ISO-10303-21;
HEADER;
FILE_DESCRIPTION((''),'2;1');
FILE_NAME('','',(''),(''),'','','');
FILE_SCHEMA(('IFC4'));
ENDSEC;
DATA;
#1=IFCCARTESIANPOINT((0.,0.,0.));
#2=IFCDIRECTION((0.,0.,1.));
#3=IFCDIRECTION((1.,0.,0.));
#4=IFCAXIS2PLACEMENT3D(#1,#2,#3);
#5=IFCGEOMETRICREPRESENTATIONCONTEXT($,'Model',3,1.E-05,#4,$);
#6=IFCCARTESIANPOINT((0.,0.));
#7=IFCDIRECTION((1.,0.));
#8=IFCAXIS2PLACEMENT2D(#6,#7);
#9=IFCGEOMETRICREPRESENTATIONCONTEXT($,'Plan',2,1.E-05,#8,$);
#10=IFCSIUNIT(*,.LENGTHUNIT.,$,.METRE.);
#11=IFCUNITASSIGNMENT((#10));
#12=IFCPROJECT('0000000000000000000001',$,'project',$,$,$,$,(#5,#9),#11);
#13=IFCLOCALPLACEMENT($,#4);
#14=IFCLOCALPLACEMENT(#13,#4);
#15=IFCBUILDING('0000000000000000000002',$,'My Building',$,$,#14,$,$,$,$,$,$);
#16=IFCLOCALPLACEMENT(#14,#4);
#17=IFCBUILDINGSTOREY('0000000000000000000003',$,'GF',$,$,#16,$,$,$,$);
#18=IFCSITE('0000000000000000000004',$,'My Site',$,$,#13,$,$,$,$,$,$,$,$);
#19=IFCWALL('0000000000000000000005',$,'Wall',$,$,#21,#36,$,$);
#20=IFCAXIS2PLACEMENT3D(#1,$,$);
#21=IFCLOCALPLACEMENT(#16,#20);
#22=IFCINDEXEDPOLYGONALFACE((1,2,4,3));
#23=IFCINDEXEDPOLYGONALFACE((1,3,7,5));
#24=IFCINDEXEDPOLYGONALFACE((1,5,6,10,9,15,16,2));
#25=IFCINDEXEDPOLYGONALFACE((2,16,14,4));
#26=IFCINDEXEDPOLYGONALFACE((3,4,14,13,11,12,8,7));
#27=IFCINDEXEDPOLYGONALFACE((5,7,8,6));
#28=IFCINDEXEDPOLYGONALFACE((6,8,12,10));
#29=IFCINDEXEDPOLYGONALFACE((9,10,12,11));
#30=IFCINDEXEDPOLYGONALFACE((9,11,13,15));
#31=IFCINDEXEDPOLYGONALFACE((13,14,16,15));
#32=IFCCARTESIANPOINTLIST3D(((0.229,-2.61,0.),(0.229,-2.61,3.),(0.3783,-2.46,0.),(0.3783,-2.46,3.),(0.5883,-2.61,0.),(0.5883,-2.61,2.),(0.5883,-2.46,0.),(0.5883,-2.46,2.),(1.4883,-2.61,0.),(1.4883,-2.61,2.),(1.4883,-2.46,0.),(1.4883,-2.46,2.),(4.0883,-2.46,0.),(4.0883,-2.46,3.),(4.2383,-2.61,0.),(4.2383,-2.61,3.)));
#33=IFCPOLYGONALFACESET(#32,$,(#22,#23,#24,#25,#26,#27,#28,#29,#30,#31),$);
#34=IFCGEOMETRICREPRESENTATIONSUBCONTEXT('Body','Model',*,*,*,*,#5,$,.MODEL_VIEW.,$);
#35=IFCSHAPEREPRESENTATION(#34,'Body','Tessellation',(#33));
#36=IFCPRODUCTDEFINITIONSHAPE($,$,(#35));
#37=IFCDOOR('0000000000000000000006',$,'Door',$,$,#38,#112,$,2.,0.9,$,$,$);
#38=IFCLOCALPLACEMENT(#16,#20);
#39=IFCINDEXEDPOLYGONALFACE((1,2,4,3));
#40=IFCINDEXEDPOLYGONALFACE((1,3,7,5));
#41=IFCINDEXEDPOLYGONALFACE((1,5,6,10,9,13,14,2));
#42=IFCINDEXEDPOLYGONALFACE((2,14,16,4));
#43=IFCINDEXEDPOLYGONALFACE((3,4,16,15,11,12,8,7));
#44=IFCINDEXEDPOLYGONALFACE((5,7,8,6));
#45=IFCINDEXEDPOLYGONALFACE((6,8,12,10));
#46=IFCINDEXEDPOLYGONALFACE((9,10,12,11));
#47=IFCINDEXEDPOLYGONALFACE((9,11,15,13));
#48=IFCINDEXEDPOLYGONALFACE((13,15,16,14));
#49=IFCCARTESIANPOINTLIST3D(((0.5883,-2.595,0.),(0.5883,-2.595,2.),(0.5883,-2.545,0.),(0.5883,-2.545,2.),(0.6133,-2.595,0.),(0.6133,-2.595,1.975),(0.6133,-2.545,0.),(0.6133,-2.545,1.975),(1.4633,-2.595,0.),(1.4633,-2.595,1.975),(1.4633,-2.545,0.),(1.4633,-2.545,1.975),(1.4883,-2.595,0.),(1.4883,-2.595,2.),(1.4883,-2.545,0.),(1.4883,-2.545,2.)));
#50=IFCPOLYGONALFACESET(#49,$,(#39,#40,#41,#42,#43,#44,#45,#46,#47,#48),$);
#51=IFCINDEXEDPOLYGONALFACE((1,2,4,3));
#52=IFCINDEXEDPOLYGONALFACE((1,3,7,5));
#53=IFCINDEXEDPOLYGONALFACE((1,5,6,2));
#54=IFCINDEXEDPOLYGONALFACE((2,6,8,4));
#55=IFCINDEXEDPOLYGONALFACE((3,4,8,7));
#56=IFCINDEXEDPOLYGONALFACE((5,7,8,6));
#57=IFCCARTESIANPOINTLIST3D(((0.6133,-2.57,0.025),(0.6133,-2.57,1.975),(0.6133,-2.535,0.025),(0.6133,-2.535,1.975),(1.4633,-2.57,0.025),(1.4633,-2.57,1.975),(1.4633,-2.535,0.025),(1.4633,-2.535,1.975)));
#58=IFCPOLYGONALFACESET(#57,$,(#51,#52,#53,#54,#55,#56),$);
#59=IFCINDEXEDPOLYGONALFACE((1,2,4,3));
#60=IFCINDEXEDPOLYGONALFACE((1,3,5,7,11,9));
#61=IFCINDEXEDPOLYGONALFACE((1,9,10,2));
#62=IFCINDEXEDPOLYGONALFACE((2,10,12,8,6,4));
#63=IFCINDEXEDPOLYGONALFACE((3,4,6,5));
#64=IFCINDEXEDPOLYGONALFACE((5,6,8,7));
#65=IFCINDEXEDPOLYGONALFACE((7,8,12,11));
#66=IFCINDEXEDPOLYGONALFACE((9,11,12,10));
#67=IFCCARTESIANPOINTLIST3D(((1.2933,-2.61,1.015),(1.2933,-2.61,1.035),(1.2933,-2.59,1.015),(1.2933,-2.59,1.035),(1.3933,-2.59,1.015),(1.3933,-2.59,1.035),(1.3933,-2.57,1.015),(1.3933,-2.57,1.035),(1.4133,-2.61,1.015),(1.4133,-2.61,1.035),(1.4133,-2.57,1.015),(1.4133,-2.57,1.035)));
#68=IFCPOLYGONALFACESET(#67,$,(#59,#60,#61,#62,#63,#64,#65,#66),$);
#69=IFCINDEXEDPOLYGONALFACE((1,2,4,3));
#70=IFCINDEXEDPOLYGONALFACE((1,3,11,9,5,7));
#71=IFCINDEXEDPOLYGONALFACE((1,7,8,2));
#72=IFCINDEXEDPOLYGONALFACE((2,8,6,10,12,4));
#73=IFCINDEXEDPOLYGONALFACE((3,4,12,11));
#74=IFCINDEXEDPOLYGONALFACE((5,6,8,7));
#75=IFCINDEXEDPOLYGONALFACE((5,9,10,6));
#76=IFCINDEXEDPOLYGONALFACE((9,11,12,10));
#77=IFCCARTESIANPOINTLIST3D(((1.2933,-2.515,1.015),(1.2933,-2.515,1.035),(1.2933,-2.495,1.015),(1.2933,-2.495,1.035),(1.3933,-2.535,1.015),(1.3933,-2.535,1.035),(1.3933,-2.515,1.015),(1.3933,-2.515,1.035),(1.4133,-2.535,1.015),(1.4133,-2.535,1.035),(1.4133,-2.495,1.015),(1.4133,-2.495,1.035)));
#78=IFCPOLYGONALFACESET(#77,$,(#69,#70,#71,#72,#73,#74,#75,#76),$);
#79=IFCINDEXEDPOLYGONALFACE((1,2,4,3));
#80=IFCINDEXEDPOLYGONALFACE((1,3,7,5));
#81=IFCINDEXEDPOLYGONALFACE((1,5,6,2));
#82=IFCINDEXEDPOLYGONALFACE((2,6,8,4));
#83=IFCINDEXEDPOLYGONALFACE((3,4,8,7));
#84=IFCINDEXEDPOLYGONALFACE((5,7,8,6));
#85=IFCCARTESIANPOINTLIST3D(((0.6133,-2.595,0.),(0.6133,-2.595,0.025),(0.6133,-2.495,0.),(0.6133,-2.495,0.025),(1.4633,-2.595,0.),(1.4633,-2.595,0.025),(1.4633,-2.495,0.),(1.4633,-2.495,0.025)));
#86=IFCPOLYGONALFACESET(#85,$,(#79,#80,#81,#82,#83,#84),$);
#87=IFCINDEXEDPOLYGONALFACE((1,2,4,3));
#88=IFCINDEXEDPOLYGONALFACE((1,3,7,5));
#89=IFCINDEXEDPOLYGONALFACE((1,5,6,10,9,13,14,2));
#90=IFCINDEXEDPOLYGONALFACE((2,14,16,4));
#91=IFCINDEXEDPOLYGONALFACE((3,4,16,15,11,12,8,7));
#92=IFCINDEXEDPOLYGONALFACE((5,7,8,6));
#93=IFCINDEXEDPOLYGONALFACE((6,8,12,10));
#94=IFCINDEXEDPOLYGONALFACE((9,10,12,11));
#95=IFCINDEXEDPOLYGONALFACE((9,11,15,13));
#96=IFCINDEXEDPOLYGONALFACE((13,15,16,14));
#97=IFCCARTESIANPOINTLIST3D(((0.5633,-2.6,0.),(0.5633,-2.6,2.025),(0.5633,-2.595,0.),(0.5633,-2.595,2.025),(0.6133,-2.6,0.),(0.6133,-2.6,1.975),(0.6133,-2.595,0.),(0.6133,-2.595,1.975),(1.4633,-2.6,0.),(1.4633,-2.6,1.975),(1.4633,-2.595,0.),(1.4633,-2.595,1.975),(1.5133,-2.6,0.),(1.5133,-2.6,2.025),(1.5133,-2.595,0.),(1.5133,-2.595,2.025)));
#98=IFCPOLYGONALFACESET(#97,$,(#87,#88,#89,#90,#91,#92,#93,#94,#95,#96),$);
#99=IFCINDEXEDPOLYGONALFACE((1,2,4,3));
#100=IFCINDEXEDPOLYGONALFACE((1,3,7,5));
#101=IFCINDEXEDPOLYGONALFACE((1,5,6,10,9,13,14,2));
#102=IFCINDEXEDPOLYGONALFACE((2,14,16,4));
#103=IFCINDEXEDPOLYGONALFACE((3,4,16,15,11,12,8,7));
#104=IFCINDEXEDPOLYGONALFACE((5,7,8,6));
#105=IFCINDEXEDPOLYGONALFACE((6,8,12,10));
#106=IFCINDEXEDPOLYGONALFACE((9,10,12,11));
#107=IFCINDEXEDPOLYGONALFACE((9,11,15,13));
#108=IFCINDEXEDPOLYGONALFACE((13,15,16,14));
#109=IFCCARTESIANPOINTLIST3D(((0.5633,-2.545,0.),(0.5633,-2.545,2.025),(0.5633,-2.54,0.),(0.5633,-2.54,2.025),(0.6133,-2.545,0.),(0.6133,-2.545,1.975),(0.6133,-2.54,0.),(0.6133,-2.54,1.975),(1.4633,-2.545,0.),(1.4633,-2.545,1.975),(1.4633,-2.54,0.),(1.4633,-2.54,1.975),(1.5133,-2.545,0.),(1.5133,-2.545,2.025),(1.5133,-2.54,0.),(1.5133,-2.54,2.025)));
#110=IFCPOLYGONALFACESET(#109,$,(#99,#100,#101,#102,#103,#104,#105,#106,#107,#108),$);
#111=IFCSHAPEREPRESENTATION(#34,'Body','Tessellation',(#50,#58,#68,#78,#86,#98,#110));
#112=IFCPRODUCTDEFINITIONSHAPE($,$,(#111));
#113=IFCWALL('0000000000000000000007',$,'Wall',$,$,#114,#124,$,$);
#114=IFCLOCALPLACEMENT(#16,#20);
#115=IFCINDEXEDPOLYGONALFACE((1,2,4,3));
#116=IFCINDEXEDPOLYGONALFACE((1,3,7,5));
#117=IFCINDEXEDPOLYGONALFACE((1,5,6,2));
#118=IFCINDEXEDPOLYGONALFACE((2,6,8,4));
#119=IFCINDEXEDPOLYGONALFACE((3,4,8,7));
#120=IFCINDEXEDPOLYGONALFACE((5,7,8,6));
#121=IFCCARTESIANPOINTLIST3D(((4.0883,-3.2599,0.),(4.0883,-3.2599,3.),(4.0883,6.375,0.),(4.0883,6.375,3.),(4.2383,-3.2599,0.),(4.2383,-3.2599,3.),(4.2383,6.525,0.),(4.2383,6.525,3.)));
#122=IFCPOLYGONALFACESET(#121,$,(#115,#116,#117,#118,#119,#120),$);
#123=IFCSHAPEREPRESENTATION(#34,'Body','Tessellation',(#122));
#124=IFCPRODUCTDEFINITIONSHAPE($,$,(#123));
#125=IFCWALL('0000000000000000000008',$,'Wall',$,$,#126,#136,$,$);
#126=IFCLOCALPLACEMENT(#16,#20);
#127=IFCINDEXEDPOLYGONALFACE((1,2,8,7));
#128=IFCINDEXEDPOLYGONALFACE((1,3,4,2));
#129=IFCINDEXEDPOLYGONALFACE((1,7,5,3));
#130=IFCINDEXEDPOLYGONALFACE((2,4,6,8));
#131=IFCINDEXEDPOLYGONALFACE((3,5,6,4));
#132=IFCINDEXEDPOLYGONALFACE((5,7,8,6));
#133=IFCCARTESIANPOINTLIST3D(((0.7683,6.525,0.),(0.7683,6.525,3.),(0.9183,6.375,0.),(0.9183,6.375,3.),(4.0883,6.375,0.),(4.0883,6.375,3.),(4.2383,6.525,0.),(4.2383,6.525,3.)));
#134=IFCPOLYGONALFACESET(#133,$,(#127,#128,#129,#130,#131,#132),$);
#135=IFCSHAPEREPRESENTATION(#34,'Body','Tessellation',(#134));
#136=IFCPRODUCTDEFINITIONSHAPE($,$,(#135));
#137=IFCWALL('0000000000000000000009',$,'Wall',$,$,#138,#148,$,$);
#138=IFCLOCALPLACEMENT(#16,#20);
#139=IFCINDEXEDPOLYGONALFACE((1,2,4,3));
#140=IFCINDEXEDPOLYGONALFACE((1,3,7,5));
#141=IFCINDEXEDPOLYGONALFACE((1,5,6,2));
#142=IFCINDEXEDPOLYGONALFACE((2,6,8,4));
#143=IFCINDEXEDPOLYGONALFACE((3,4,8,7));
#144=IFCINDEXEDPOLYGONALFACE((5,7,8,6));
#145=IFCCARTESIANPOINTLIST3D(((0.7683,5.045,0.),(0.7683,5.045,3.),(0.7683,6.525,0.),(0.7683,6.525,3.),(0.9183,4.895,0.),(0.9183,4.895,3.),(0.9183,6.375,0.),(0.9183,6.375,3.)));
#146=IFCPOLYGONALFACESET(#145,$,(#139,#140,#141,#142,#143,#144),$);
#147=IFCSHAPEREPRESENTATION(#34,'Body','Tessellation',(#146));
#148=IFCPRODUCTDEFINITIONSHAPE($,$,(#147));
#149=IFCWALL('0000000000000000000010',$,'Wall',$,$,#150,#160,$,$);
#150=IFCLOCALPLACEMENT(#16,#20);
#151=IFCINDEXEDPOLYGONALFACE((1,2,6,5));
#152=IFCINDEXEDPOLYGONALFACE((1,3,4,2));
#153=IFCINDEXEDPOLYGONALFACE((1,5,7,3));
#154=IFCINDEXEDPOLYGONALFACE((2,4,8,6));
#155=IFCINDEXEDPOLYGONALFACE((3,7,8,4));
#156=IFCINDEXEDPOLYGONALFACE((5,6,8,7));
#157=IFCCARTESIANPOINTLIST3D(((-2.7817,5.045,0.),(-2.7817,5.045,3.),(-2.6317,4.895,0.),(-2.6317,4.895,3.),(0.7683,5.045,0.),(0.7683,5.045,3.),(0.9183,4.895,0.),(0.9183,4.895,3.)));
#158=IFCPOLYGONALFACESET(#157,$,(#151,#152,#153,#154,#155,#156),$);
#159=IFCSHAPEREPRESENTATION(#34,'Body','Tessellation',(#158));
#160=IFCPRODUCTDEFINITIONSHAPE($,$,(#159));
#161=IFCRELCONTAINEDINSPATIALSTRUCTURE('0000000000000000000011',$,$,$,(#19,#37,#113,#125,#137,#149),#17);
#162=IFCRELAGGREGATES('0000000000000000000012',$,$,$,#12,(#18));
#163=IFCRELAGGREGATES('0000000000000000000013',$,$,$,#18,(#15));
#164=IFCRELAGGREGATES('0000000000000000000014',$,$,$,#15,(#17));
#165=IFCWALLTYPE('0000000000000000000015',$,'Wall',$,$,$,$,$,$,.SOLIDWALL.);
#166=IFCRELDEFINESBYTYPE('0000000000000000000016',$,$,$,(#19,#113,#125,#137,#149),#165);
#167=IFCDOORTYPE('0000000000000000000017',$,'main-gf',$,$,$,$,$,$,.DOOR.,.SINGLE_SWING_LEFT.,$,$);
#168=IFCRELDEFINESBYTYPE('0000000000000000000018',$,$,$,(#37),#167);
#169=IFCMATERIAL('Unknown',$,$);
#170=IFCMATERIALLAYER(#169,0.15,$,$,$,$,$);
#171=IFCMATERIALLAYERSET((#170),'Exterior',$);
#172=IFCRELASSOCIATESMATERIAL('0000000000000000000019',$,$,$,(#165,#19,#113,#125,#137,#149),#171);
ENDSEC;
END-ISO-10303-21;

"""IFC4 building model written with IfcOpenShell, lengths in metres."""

from ifc_helpers import new_model, entity, si_unit, frame, origin_with_axes, origin_2d_with_axis, place, context, subcontext, project, spatial, line, indexed_curve, outline, extrude, shape, source, transform, mapped, material, layer, layer_set, layer_usage, type_object, type_shapes, element, fill, save


model = new_model("IFC4")

# Units and contexts
model_context = context("Model", 3, precision=1e-05, world=origin_with_axes())
plan_context = context("Plan", 2, precision=1e-05, world=origin_2d_with_axis())
body_context_1 = subcontext(model_context, "Body", "Model", "MODEL_VIEW")
body_context_2 = subcontext(plan_context, "Body", "Plan", "PLAN_VIEW")
ifc_project = project(units=[si_unit("LENGTHUNIT", "METRE")], contexts=[model_context, plan_context])

# Site, building, storey
site_placement = place(None, origin_with_axes())
site = spatial("IfcSite", under=ifc_project, at=site_placement, Name="My Site")
building_placement = place(site_placement, origin_with_axes())
building = spatial("IfcBuilding", under=site, at=building_placement, Name="My Building")
storey_placement = place(building_placement, origin_with_axes())
storey = spatial("IfcBuildingStorey", under=building, at=storey_placement, Name="GF")

# Wall, opening, door
ifc_material = material(Name="Unknown")
ifc_layer_1 = layer(ifc_material, 0.15)
ifc_layer_set_1 = layer_set([ifc_layer_1], Name="Exterior")
ifc_layer_usage_1 = layer_usage(ifc_layer_set_1, "AXIS2", "POSITIVE", 0.0)
wall_type_1 = type_object("IfcWallType", Name="Wall", PredefinedType="SOLIDWALL", material=ifc_layer_set_1)
wall_1_placement = place(storey_placement, frame((0.229, -2.61, 0.0), z_axis=(0.0, 0.0, 1.0), x_axis=(1.0, 0.0, 0.0)))
wall_1 = element("IfcWall", 1, at=wall_1_placement, inside=storey, type_object=wall_type_1, material=ifc_layer_usage_1, Name="Wall", context=body_context_1, shape_type="SweptSolid", body=[
    extrude(outline(indexed_curve([(0.0, 0.0), (0.1494, 0.15), (3.8594, 0.15), (4.0094, 0.0)], segments=[line(1, 2, 3, 4, 1)])), origin_with_axes(), (0.0, 0.0, 1.0), 3.0),
])
shared_shape_1 = source(origin_with_axes(), body_context_1, "Body", "SweptSolid", [
    extrude(outline(indexed_curve([(0.0, 0.0), (0.9, 0.0), (0.9, 2.0), (0.0, 2.0)], segments=[line(1, 2, 3, 4, 1)])), frame((0.0, -0.6, 0.0), z_axis=(0.0, -1.0, 0.0), x_axis=(1.0, 0.0, 0.0)), (0.0, 0.0, -1.0), 1.2),
])
opening_1_placement = place(wall_1_placement, frame((0.3593, 0.015, 0.0), z_axis=(0.0, 0.0, 1.0), x_axis=(1.0, -0.000001, 0.0)))
opening_1 = element("IfcOpeningElement", 2, at=opening_1_placement, cuts=wall_1, PredefinedType="OPENING", context=body_context_1, shape_type="MappedRepresentation", body=[
    mapped(shared_shape_1, transform((0.0, 0.0, 0.0), x_axis=(1.0, 0.0, 0.0), y_axis=(0.0, 1.0, 0.0), z_axis=(0.0, 0.0, 1.0), scale=1.0)),
])
door_type = type_object("IfcDoorType", Name="main-gf", OperationType="SINGLE_SWING_LEFT", PredefinedType="DOOR")
shared_shape_2 = source(origin_with_axes(), body_context_1, "Body", "SweptSolid", [
    extrude(outline(indexed_curve([(0.0, 0.0), (0.0, 2.0), (0.9, 2.0), (0.9, 0.0), (0.875, 0.0), (0.875, 1.975), (0.025, 1.975), (0.025, 0.0)], segments=[line(1, 2, 3, 4, 5, 6, 7, 8, 1)])), frame((0.0, 0.0, 0.0), z_axis=(0.0, -1.0, 0.0), x_axis=(1.0, 0.0, 0.0)), (0.0, 0.0, -1.0), 0.05),
    extrude(outline(indexed_curve([(0.0, 0.0), (0.85, 0.0), (0.85, 0.035), (0.0, 0.035)], segments=[line(1, 2, 3, 4, 1)])), frame((0.025, 0.025, 0.025), z_axis=(0.0, 0.0, 1.0), x_axis=(1.0, 0.0, 0.0)), (0.0, 0.0, 1.0), 1.95),
    extrude(outline(indexed_curve([(0.0, 0.0), (0.0, -0.04), (-0.12, -0.04), (-0.12, -0.02), (-0.02, -0.02), (-0.02, 0.0)], segments=[line(1, 2, 3, 4, 5, 6, 1)])), frame((0.825, 0.025, 1.015), z_axis=(0.0, 0.0, 1.0), x_axis=(1.0, 0.0, 0.0)), (0.0, 0.0, 1.0), 0.02),
    extrude(outline(indexed_curve([(0.0, 0.0), (0.0, 0.04), (-0.12, 0.04), (-0.12, 0.02), (-0.02, 0.02), (-0.02, 0.0)], segments=[line(1, 2, 3, 4, 5, 6, 1)])), frame((0.825, 0.06, 1.015), z_axis=(0.0, 0.0, 1.0), x_axis=(1.0, 0.0, 0.0)), (0.0, 0.0, 1.0), 0.02),
    extrude(outline(indexed_curve([(0.0, 0.0), (0.85, 0.0), (0.85, 0.1), (0.0, 0.1)], segments=[line(1, 2, 3, 4, 1)])), frame((0.025, 0.0, 0.0), z_axis=(0.0, 0.0, 1.0), x_axis=(1.0, 0.0, 0.0)), (0.0, 0.0, 1.0), 0.025),
    extrude(outline(indexed_curve([(0.0, 0.0), (0.0, 2.025), (0.95, 2.025), (0.95, 0.0), (0.9, 0.0), (0.9, 1.975), (0.05, 1.975), (0.05, 0.0)], segments=[line(1, 2, 3, 4, 5, 6, 7, 8, 1)])), frame((-0.025, -0.005, 0.0), z_axis=(0.0, -1.0, 0.0), x_axis=(1.0, 0.0, 0.0)), (0.0, 0.0, -1.0), 0.005),
    extrude(outline(indexed_curve([(0.0, 0.0), (0.0, 2.025), (0.95, 2.025), (0.95, 0.0), (0.9, 0.0), (0.9, 1.975), (0.05, 1.975), (0.05, 0.0)], segments=[line(1, 2, 3, 4, 5, 6, 7, 8, 1)])), frame((-0.025, 0.05, 0.0), z_axis=(0.0, -1.0, 0.0), x_axis=(1.0, 0.0, 0.0)), (0.0, 0.0, -1.0), 0.005),
])
shared_shape_3 = source(origin_with_axes(), body_context_2, "Body", "Curve2D", [
    entity("IfcIndexedPolyCurve", entity("IfcCartesianPointList2D", [[0.0, 0.0], [0.025, 0.0], [0.025, 0.05], [0.0, 0.05]]), [entity("IfcLineIndex", [1, 2, 3, 4, 1])]),
    entity("IfcIndexedPolyCurve", entity("IfcCartesianPointList2D", [[0.9, 0.0], [0.875, 0.0], [0.875, 0.05], [0.9, 0.05]]), [entity("IfcLineIndex", [1, 2, 3, 4, 1])]),
    entity("IfcIndexedPolyCurve", entity("IfcCartesianPointList2D", [[0.025, 0.05], [0.025, -0.8], [0.06, -0.8]])),
    entity("IfcTrimmedCurve", entity("IfcEllipse", entity("IfcAxis2Placement2D", entity("IfcCartesianPoint", [0.06, 0.05]), entity("IfcDirection", [1.0, 0.0])), 0.815, 0.85), [entity("IfcCartesianPoint", [0.06, -0.8])], [entity("IfcCartesianPoint", [0.06, 0.9])], True, "CARTESIAN"),
    entity("IfcIndexedPolyCurve", entity("IfcCartesianPointList2D", [[0.025, 0.05], [0.06, 0.05], [0.06, 0.9], [0.025, 0.9]]), [entity("IfcLineIndex", [1, 2, 3, 4, 1])]),
])
type_shapes(door_type, [shared_shape_2, shared_shape_3])
door_1_placement = place(opening_1_placement, origin_with_axes())
door_1 = element("IfcDoor", 3, at=door_1_placement, inside=storey, type_object=door_type, Name="Door", OverallHeight=2.0, OverallWidth=0.9, shapes=[
    shape(body_context_1, "Body", "MappedRepresentation", [mapped(shared_shape_2, transform((0.0, 0.0, 0.0), x_axis=(1.0, 0.0, 0.0), y_axis=(0.0, 1.0, 0.0), z_axis=(0.0, 0.0, 1.0), scale=1.0))]),
    shape(body_context_2, "Body", "MappedRepresentation", [mapped(shared_shape_3, transform((0.0, 0.0, 0.0), x_axis=(1.0, 0.0, 0.0), y_axis=(0.0, 1.0, 0.0), z_axis=(0.0, 0.0, 1.0), scale=1.0))]),
])
fill(opening_1, door_1)

# Walls
ifc_layer_usage_2 = layer_usage(ifc_layer_set_1, "AXIS2", "POSITIVE", 0.0)
wall_2_placement = place(storey_placement, frame((4.2383, -3.2599, 0.0), z_axis=(0.0, 0.0, 1.0), x_axis=(0.0, 1.0, 0.0)))
element("IfcWall", 4, at=wall_2_placement, inside=storey, type_object=wall_type_1, material=ifc_layer_usage_2, Name="Wall", context=body_context_1, shape_type="SweptSolid", body=[
    extrude(outline(indexed_curve([(0.0, 0.0), (0.0, 0.15), (9.6349, 0.15), (9.7849, 0.0)], segments=[line(1, 2, 3, 4, 1)])), origin_with_axes(), (0.0, 0.0, 1.0), 3.0),
])
ifc_layer_usage_3 = layer_usage(ifc_layer_set_1, "AXIS2", "POSITIVE", 0.0)
wall_3_placement = place(storey_placement, frame((4.2383, 6.525, 0.0), z_axis=(0.0, 0.0, 1.0), x_axis=(-1.0, 0.0, 0.0)))
element("IfcWall", 5, at=wall_3_placement, inside=storey, type_object=wall_type_1, material=ifc_layer_usage_3, Name="Wall", context=body_context_1, shape_type="SweptSolid", body=[
    extrude(outline(indexed_curve([(0.0, 0.0), (0.15, 0.15), (3.32, 0.15), (3.47, 0.0)], segments=[line(1, 2, 3, 4, 1)])), origin_with_axes(), (0.0, 0.0, 1.0), 3.0),
])
ifc_layer_usage_4 = layer_usage(ifc_layer_set_1, "AXIS2", "POSITIVE", 0.0)
wall_4_placement = place(storey_placement, frame((0.7683, 6.525, 0.0), z_axis=(0.0, 0.0, 1.0), x_axis=(0.0, -1.0, 0.0)))
element("IfcWall", 6, at=wall_4_placement, inside=storey, type_object=wall_type_1, material=ifc_layer_usage_4, Name="Wall", context=body_context_1, shape_type="SweptSolid", body=[
    extrude(outline(indexed_curve([(0.0, 0.0), (0.15, 0.15), (1.63, 0.15), (1.48, 0.0)], segments=[line(1, 2, 3, 4, 1)])), origin_with_axes(), (0.0, 0.0, 1.0), 3.0),
])
ifc_layer_usage_5 = layer_usage(ifc_layer_set_1, "AXIS2", "POSITIVE", 0.0)
wall_5_placement = place(storey_placement, frame((0.7683, 5.045, 0.0), z_axis=(0.0, 0.0, 1.0), x_axis=(-1.0, 0.0, 0.0)))
element("IfcWall", 7, at=wall_5_placement, inside=storey, type_object=wall_type_1, material=ifc_layer_usage_5, Name="Wall", context=body_context_1, shape_type="SweptSolid", body=[
    extrude(outline(indexed_curve([(0.0, 0.0), (-0.15, 0.15), (3.4, 0.15), (3.55, 0.0)], segments=[line(1, 2, 3, 4, 1)])), origin_with_axes(), (0.0, 0.0, 1.0), 3.0),
])

save(model, "model.ifc")
